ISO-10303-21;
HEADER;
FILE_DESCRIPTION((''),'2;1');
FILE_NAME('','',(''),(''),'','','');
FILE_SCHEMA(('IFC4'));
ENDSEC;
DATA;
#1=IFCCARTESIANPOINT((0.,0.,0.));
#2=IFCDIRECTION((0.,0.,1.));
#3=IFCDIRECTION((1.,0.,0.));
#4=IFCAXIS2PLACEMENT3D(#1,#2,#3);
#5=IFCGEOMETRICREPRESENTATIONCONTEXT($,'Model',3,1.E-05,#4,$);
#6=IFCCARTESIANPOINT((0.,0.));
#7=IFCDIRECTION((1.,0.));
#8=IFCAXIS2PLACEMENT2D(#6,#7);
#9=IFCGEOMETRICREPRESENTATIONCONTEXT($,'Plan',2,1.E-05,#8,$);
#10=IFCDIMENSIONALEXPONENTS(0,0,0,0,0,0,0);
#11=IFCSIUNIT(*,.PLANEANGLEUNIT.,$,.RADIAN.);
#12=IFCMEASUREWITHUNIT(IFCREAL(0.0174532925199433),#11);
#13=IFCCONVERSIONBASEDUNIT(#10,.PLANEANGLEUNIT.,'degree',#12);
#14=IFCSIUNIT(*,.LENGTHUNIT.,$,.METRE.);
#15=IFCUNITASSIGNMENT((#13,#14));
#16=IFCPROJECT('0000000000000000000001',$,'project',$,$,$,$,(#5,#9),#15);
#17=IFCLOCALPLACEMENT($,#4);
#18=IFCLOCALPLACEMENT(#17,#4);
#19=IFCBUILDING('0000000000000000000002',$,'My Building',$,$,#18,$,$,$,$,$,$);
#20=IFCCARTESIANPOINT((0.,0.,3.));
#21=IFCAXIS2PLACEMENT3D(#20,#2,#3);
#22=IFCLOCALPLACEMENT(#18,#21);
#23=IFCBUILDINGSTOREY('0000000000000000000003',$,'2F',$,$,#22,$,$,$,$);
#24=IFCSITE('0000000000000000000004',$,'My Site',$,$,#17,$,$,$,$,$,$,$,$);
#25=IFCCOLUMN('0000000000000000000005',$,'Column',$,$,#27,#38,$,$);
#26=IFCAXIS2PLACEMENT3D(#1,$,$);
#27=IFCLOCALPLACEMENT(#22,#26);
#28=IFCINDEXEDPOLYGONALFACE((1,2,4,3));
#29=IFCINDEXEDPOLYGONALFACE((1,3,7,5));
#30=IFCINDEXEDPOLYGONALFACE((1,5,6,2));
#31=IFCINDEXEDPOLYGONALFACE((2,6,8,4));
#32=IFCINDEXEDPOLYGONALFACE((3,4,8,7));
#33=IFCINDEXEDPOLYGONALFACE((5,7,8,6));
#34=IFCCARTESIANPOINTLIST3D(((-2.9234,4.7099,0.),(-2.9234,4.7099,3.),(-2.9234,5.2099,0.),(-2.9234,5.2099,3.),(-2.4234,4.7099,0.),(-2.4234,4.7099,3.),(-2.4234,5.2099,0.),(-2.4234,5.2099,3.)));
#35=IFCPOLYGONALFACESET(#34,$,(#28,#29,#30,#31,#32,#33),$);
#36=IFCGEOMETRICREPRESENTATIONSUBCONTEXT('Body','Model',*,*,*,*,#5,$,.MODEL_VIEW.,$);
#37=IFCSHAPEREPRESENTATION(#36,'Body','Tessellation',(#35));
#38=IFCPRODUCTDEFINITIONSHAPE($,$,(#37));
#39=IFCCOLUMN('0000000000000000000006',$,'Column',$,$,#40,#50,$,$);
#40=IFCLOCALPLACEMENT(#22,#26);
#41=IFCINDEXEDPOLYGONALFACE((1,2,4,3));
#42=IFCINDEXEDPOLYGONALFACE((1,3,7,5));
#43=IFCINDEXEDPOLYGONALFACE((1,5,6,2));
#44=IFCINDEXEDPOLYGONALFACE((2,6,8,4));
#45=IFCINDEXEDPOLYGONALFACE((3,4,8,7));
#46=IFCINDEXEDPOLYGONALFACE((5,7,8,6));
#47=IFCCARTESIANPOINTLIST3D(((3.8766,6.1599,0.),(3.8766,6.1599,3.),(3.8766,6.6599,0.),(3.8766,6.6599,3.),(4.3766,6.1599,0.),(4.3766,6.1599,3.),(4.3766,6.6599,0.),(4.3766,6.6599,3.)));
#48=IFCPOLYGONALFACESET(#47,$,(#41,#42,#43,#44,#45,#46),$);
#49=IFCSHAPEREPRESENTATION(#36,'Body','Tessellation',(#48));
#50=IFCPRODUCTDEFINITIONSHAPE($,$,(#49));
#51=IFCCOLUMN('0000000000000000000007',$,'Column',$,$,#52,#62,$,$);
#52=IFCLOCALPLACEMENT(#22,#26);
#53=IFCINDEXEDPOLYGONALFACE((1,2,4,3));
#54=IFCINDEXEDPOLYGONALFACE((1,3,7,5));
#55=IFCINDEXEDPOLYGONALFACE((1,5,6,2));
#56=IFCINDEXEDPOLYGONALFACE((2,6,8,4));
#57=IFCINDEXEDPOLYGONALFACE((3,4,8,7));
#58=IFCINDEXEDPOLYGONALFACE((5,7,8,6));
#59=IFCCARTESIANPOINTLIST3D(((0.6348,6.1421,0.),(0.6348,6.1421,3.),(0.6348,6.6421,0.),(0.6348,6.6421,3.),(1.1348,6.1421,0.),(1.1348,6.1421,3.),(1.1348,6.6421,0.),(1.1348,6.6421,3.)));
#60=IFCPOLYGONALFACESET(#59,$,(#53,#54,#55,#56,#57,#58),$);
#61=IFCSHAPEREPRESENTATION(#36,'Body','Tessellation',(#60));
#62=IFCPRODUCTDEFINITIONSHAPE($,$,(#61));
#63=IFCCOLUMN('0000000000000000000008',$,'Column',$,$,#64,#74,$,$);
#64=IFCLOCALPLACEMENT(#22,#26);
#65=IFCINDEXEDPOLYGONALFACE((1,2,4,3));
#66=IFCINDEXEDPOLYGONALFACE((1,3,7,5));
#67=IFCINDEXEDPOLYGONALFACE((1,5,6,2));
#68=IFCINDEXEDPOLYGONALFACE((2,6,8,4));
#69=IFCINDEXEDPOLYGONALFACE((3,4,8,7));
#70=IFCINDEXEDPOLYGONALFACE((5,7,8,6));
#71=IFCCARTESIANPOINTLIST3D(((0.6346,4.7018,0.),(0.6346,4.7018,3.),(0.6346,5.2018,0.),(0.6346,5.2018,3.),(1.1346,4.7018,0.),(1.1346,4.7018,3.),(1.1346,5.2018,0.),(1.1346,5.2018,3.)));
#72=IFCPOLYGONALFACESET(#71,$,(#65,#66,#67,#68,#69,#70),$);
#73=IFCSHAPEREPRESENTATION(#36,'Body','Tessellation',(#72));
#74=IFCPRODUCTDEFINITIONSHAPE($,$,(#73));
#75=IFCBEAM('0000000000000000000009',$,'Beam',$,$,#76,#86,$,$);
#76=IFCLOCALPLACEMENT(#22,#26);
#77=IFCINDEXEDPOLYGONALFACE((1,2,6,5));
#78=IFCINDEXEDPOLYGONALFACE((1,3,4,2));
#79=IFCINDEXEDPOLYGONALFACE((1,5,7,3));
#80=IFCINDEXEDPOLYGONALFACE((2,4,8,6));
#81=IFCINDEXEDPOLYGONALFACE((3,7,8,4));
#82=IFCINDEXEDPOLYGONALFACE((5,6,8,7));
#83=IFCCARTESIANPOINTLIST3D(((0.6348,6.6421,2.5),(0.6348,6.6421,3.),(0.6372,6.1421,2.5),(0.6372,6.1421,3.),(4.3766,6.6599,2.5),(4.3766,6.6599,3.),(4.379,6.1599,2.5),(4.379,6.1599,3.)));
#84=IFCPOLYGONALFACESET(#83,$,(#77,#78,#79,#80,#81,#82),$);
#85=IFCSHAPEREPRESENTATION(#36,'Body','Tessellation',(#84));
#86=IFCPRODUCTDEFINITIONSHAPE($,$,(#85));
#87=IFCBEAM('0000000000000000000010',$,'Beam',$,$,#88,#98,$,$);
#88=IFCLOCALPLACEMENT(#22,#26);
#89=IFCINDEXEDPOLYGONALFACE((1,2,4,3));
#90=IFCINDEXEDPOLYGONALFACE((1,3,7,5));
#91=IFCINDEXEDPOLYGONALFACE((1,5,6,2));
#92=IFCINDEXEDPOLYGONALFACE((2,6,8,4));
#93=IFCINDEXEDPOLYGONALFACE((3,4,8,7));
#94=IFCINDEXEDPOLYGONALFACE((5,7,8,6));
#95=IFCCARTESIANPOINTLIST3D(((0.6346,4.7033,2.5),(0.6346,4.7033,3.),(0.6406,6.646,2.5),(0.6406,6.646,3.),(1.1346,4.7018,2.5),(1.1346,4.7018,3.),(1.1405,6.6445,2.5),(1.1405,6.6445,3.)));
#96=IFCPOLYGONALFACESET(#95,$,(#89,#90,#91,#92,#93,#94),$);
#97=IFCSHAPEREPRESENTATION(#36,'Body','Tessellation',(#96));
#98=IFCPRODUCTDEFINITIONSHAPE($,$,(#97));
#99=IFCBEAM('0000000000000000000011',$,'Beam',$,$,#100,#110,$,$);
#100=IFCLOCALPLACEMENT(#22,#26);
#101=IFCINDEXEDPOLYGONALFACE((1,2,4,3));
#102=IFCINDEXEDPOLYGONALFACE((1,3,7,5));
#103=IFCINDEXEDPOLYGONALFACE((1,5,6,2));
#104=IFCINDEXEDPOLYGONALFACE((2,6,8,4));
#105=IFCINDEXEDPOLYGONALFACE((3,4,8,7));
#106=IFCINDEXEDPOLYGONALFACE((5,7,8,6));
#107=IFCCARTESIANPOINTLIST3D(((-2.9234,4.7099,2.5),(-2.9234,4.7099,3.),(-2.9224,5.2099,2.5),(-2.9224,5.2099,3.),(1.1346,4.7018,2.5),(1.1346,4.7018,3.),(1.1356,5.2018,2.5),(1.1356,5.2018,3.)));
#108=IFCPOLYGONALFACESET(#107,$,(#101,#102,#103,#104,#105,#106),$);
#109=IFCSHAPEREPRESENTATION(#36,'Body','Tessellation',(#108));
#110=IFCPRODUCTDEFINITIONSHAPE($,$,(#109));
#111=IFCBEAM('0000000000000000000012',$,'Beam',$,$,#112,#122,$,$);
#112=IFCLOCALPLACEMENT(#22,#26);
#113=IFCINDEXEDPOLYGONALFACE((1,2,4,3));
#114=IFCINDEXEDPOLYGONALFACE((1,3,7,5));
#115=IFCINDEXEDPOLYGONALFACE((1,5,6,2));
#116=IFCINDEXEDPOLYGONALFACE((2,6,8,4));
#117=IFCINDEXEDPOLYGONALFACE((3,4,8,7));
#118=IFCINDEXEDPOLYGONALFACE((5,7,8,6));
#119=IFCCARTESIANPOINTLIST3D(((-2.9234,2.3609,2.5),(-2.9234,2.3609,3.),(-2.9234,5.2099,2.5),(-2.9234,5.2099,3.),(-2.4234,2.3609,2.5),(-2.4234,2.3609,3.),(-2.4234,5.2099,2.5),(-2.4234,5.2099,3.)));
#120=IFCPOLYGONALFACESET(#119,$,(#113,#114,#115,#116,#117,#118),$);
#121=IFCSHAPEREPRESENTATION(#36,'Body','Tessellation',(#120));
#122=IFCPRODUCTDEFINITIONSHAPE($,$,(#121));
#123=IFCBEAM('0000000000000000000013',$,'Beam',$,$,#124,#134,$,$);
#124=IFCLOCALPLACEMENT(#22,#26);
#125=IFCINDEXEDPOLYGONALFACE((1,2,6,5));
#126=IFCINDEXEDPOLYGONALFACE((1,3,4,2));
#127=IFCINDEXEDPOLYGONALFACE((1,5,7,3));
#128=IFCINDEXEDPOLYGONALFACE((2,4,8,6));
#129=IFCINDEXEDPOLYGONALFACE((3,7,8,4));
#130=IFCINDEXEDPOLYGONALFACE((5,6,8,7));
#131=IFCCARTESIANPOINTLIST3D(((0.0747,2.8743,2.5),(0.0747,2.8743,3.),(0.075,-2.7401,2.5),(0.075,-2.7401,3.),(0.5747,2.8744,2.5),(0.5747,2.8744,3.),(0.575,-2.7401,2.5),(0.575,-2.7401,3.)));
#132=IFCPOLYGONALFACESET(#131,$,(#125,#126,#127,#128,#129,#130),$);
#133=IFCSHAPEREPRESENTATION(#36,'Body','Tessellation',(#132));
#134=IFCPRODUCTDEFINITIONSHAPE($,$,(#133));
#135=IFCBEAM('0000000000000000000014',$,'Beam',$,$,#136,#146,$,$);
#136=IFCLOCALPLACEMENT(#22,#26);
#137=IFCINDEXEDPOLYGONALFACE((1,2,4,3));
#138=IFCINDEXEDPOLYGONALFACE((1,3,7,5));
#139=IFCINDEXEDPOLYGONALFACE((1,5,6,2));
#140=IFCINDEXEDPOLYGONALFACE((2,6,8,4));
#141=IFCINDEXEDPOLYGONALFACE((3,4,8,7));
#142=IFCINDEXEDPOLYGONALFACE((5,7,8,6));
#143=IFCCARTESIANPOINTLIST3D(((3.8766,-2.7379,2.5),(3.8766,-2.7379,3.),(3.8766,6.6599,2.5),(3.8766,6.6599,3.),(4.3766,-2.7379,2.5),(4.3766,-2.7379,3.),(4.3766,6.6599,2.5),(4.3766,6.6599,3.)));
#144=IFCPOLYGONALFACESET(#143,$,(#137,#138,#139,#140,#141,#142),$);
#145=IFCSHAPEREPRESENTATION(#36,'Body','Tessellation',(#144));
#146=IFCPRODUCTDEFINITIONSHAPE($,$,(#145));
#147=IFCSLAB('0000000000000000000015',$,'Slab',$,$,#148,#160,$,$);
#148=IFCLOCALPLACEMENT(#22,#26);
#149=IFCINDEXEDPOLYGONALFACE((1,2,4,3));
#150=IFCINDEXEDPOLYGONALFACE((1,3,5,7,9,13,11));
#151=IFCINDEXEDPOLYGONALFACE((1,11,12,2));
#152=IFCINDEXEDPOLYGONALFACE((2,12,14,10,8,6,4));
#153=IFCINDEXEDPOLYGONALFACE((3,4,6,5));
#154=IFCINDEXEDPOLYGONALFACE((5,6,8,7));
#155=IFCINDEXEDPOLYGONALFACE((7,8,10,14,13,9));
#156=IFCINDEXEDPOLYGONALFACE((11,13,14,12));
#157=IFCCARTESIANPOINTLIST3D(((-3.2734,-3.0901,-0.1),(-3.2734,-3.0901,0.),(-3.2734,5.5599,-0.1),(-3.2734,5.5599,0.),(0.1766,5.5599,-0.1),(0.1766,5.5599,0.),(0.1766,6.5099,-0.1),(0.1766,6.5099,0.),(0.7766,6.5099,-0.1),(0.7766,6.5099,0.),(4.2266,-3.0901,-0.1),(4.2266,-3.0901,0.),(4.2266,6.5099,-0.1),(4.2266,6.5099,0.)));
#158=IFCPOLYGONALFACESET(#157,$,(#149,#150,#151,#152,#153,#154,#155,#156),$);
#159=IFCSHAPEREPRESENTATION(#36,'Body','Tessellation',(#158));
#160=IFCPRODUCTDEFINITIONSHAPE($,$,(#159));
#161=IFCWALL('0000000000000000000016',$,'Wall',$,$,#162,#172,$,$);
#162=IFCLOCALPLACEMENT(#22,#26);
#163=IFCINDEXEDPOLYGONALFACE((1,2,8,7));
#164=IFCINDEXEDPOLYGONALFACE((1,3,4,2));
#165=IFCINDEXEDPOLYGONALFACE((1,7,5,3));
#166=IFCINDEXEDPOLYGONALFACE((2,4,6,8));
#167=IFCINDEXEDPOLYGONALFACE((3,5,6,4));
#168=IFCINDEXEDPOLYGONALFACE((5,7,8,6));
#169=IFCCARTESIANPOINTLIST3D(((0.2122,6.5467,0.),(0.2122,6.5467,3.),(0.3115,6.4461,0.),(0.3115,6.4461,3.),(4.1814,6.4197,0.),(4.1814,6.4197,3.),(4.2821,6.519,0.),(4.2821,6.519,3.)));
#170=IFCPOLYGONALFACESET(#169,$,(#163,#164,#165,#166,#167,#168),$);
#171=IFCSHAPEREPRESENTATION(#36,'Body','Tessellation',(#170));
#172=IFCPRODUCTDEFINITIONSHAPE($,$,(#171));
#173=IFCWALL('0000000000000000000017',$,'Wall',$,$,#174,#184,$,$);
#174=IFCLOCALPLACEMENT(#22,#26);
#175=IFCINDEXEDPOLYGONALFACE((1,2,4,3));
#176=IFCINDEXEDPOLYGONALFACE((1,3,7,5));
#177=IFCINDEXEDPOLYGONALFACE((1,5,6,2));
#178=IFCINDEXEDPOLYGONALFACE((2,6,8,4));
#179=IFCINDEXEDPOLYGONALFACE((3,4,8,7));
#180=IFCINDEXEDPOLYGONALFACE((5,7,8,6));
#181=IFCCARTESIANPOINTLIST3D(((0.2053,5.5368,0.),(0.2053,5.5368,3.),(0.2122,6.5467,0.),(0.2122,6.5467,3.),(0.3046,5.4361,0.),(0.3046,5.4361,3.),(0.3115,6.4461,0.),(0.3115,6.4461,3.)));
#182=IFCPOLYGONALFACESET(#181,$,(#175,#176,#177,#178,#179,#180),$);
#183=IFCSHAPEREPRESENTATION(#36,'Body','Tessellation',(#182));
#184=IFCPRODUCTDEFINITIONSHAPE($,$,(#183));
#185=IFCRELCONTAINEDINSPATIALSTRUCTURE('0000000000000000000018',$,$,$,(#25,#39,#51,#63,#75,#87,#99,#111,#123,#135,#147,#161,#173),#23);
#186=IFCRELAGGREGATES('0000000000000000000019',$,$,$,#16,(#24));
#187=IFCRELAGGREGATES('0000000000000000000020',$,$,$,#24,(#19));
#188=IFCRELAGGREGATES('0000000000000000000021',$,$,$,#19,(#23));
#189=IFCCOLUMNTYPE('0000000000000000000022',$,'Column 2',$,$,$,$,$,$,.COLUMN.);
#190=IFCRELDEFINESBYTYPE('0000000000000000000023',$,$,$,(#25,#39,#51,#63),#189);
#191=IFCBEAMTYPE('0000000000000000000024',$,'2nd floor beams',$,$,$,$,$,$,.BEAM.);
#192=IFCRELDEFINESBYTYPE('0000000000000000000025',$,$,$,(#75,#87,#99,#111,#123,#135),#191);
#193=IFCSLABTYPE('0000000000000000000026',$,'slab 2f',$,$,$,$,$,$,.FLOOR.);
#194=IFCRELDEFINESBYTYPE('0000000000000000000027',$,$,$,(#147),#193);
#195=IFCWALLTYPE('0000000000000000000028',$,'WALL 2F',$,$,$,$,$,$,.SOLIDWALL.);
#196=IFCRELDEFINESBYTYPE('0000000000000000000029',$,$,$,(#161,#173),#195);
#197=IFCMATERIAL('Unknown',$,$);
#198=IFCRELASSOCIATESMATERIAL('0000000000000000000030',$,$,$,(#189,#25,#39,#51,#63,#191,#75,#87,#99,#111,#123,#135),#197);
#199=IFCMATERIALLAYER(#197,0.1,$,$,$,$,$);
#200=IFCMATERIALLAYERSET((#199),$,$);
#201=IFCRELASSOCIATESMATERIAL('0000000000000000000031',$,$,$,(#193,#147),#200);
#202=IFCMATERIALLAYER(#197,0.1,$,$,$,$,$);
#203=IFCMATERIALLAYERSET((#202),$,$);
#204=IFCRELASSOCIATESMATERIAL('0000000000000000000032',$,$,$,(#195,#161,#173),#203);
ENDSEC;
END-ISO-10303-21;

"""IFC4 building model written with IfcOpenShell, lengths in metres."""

from ifc_helpers import new_model, entity, si_unit, converted_unit, frame, origin_with_axes, origin_2d_with_axis, place, context, subcontext, project, spatial, line, indexed_curve, rectangle, outline, extrude, material, layer, layer_set, layer_usage, material_profile, profile_set, profile_usage, type_object, element, save


model = new_model("IFC4")

# Units and contexts
model_context = context("Model", 3, precision=1e-05, world=origin_with_axes())
plan_context = context("Plan", 2, precision=1e-05, world=origin_2d_with_axis())
body_context_1 = subcontext(model_context, "Body", "Model", "MODEL_VIEW")
ifc_project = project(units=[converted_unit("PLANEANGLEUNIT", "degree", entity("IfcReal", 0.0174532925199433), si_unit("PLANEANGLEUNIT", "RADIAN"), dimensions=[0, 0, 0, 0, 0, 0, 0]), si_unit("LENGTHUNIT", "METRE")], contexts=[model_context, plan_context])

# Site, building, storey
site_placement = place(None, origin_with_axes())
site = spatial("IfcSite", under=ifc_project, at=site_placement, Name="My Site")
building_placement = place(site_placement, origin_with_axes())
building = spatial("IfcBuilding", under=site, at=building_placement, Name="My Building")
storey_placement = place(building_placement, frame((0.0, 0.0, 3.0), z_axis=(0.0, 0.0, 1.0), x_axis=(1.0, 0.0, 0.0)))
storey = spatial("IfcBuildingStorey", under=building, at=storey_placement, Name="2F")

# Columns
ifc_material = material(Name="Unknown")
ifc_material_profile_1 = material_profile(ifc_material, rectangle(XDim=0.5, YDim=0.5))
ifc_profile_set_1 = profile_set([ifc_material_profile_1])
ifc_profile_usage_1 = profile_usage(ifc_profile_set_1, cardinal=5)
column_type = type_object("IfcColumnType", Name="Column 2", PredefinedType="COLUMN", material=ifc_profile_set_1)
column_1_placement = place(storey_placement, frame((-2.6734, 4.9599, 0.0), z_axis=(0.0, 0.0, 1.0), x_axis=(1.0, 0.0, 0.0)))
element("IfcColumn", 1, at=column_1_placement, inside=storey, type_object=column_type, material=ifc_profile_usage_1, Name="Column", context=body_context_1, shape_type="SweptSolid", body=[
    extrude(rectangle(XDim=0.5, YDim=0.5), origin_with_axes(), (0.0, 0.0, 1.0), 3.0),
])
ifc_profile_usage_2 = profile_usage(ifc_profile_set_1, cardinal=5)
column_2_placement = place(storey_placement, frame((4.1266, 6.4099, 0.0), z_axis=(0.0, 0.0, 1.0), x_axis=(1.0, 0.0, 0.0)))
element("IfcColumn", 2, at=column_2_placement, inside=storey, type_object=column_type, material=ifc_profile_usage_2, Name="Column", context=body_context_1, shape_type="SweptSolid", body=[
    extrude(rectangle(XDim=0.5, YDim=0.5), origin_with_axes(), (0.0, 0.0, 1.0), 3.0),
])
ifc_profile_usage_3 = profile_usage(ifc_profile_set_1, cardinal=5)
column_3_placement = place(storey_placement, frame((0.8848, 6.3921, 0.0), z_axis=(0.0, 0.0, 1.0), x_axis=(1.0, 0.0, 0.0)))
element("IfcColumn", 3, at=column_3_placement, inside=storey, type_object=column_type, material=ifc_profile_usage_3, Name="Column", context=body_context_1, shape_type="SweptSolid", body=[
    extrude(rectangle(XDim=0.5, YDim=0.5), origin_with_axes(), (0.0, 0.0, 1.0), 3.0),
])
ifc_profile_usage_4 = profile_usage(ifc_profile_set_1, cardinal=5)
column_4_placement = place(storey_placement, frame((0.8846, 4.9518, 0.0), z_axis=(0.0, 0.0, 1.0), x_axis=(1.0, 0.0, 0.0)))
element("IfcColumn", 4, at=column_4_placement, inside=storey, type_object=column_type, material=ifc_profile_usage_4, Name="Column", context=body_context_1, shape_type="SweptSolid", body=[
    extrude(rectangle(XDim=0.5, YDim=0.5), origin_with_axes(), (0.0, 0.0, 1.0), 3.0),
])

# Beams
ifc_material_profile_2 = material_profile(ifc_material, rectangle(XDim=0.5, YDim=0.5))
ifc_profile_set_2 = profile_set([ifc_material_profile_2])
ifc_profile_usage_5 = profile_usage(ifc_profile_set_2, cardinal=7)
beam_type = type_object("IfcBeamType", Name="2nd floor beams", PredefinedType="BEAM", material=ifc_profile_set_2)
beam_1_placement = place(storey_placement, frame((0.6348, 6.6421, 3.0), z_axis=(0.999989, 0.004763, 0.0), x_axis=(-0.004763, 0.999989, 0.0)))
element("IfcBeam", 5, at=beam_1_placement, inside=storey, type_object=beam_type, material=ifc_profile_usage_5, Name="Beam", context=body_context_1, shape_type="SweptSolid", body=[
    extrude(rectangle(XDim=0.5, YDim=0.5), frame((-0.25, -0.25, 0.0), z_axis=(0.0, 0.0, 1.0), x_axis=(1.0, 0.0, 0.0)), (0.0, 0.0, 1.0), 3.7418),
])
ifc_profile_usage_6 = profile_usage(ifc_profile_set_2, cardinal=7)
beam_2_placement = place(storey_placement, frame((1.1405, 6.6445, 3.0), z_axis=(-0.003055, -0.999995, 0.0), x_axis=(0.999995, -0.003055, 0.0)))
element("IfcBeam", 6, at=beam_2_placement, inside=storey, type_object=beam_type, material=ifc_profile_usage_6, Name="Beam", context=body_context_1, shape_type="SweptSolid", body=[
    extrude(rectangle(XDim=0.5, YDim=0.5), frame((-0.25, -0.25, 0.0), z_axis=(0.0, 0.0, 1.0), x_axis=(1.0, 0.0, 0.0)), (0.0, 0.0, 1.0), 1.9427),
])
ifc_profile_usage_7 = profile_usage(ifc_profile_set_2, cardinal=7)
beam_3_placement = place(storey_placement, frame((1.1346, 4.7018, 3.0), z_axis=(-0.999998, 0.002, 0.0), x_axis=(-0.002, -0.999998, 0.0)))
element("IfcBeam", 7, at=beam_3_placement, inside=storey, type_object=beam_type, material=ifc_profile_usage_7, Name="Beam", context=body_context_1, shape_type="SweptSolid", body=[
    extrude(rectangle(XDim=0.5, YDim=0.5), frame((-0.25, -0.25, 0.0), z_axis=(0.0, 0.0, 1.0), x_axis=(1.0, 0.0, 0.0)), (0.0, 0.0, 1.0), 4.058),
])
ifc_profile_usage_8 = profile_usage(ifc_profile_set_2, cardinal=7)
beam_4_placement = place(storey_placement, frame((-2.4234, 5.2099, 3.0), z_axis=(-0.000006, -1.0, 0.0), x_axis=(1.0, -0.000006, 0.0)))
element("IfcBeam", 8, at=beam_4_placement, inside=storey, type_object=beam_type, material=ifc_profile_usage_8, Name="Beam", context=body_context_1, shape_type="SweptSolid", body=[
    extrude(rectangle(XDim=0.5, YDim=0.5), frame((-0.25, -0.25, 0.0), z_axis=(0.0, 0.0, 1.0), x_axis=(1.0, 0.0, 0.0)), (0.0, 0.0, 1.0), 2.849),
])
ifc_profile_usage_9 = profile_usage(ifc_profile_set_2, cardinal=7)
beam_5_placement = place(storey_placement, frame((0.5747, 2.8744, 3.0), z_axis=(0.00005, -1.0, 0.0), x_axis=(1.0, 0.00005, 0.0)))
element("IfcBeam", 9, at=beam_5_placement, inside=storey, type_object=beam_type, material=ifc_profile_usage_9, Name="Beam", context=body_context_1, shape_type="SweptSolid", body=[
    extrude(rectangle(XDim=0.5, YDim=0.5), frame((-0.25, -0.25, 0.0), z_axis=(0.0, 0.0, 1.0), x_axis=(1.0, 0.0, 0.0)), (0.0, 0.0, 1.0), 5.6145),
])
ifc_profile_usage_10 = profile_usage(ifc_profile_set_2, cardinal=7)
beam_6_placement = place(storey_placement, frame((4.3766, 6.6599, 3.0), z_axis=(0.0, -1.0, 0.0), x_axis=(1.0, 0.0, 0.0)))
element("IfcBeam", 10, at=beam_6_placement, inside=storey, type_object=beam_type, material=ifc_profile_usage_10, Name="Beam", context=body_context_1, shape_type="SweptSolid", body=[
    extrude(rectangle(XDim=0.5, YDim=0.5), frame((-0.25, -0.25, 0.0), z_axis=(0.0, 0.0, 1.0), x_axis=(1.0, 0.0, 0.0)), (0.0, 0.0, 1.0), 9.3978),
])

# Slab
ifc_layer_1 = layer(ifc_material, 0.1)
ifc_layer_set_1 = layer_set([ifc_layer_1])
ifc_layer_usage_1 = layer_usage(ifc_layer_set_1, "AXIS3", "POSITIVE", -0.1)
slab_type = type_object("IfcSlabType", Name="slab 2f", PredefinedType="FLOOR", material=ifc_layer_set_1)
slab_placement = place(storey_placement, frame((0.7766, 6.5099, 0.0), z_axis=(0.0, 0.0, 1.0), x_axis=(1.0, 0.0, 0.0)))
element("IfcSlab", 11, at=slab_placement, inside=storey, type_object=slab_type, material=ifc_layer_usage_1, Name="Slab", context=body_context_1, shape_type="SweptSolid", body=[
    extrude(outline(indexed_curve([(0.0, 0.0), (-0.6, 0.0), (-0.6, -0.95), (-4.05, -0.95), (-4.05, -9.6), (3.45, -9.6), (3.45, 0.0), (0.0, 0.0)])), frame((0.0, 0.0, -0.1), z_axis=(0.0, 0.0, 1.0), x_axis=(1.0, 0.0, 0.0)), (0.0, 0.0, 1.0), 0.1),
])

# Walls
ifc_layer_2 = layer(ifc_material, 0.1)
ifc_layer_set_2 = layer_set([ifc_layer_2])
ifc_layer_usage_2 = layer_usage(ifc_layer_set_2, "AXIS2", "POSITIVE", 0.0)
wall_type = type_object("IfcWallType", Name="WALL 2F", PredefinedType="SOLIDWALL", material=ifc_layer_set_2)
wall_1_placement = place(storey_placement, frame((4.2821, 6.519, 0.0), z_axis=(0.0, 0.0, 1.0), x_axis=(-0.999977, 0.006814, 0.0)))
element("IfcWall", 12, at=wall_1_placement, inside=storey, type_object=wall_type, material=ifc_layer_usage_2, Name="Wall", context=body_context_1, shape_type="SweptSolid", body=[
    extrude(outline(indexed_curve([(0.0, 0.0), (0.1, 0.1), (3.97, 0.1), (4.07, 0.0)], segments=[line(1, 2, 3, 4, 1)])), origin_with_axes(), (0.0, 0.0, 1.0), 3.0),
])
ifc_layer_usage_3 = layer_usage(ifc_layer_set_2, "AXIS2", "POSITIVE", 0.0)
wall_2_placement = place(storey_placement, frame((0.2122, 6.5467, 0.0), z_axis=(0.0, 0.0, 1.0), x_axis=(-0.006815, -0.999977, 0.0)))
element("IfcWall", 13, at=wall_2_placement, inside=storey, type_object=wall_type, material=ifc_layer_usage_3, Name="Wall", context=body_context_1, shape_type="SweptSolid", body=[
    extrude(outline(indexed_curve([(0.0, 0.0), (0.1, 0.1), (1.11, 0.1), (1.01, 0.0)], segments=[line(1, 2, 3, 4, 1)])), origin_with_axes(), (0.0, 0.0, 1.0), 3.0),
])

save(model, "model.ifc")
